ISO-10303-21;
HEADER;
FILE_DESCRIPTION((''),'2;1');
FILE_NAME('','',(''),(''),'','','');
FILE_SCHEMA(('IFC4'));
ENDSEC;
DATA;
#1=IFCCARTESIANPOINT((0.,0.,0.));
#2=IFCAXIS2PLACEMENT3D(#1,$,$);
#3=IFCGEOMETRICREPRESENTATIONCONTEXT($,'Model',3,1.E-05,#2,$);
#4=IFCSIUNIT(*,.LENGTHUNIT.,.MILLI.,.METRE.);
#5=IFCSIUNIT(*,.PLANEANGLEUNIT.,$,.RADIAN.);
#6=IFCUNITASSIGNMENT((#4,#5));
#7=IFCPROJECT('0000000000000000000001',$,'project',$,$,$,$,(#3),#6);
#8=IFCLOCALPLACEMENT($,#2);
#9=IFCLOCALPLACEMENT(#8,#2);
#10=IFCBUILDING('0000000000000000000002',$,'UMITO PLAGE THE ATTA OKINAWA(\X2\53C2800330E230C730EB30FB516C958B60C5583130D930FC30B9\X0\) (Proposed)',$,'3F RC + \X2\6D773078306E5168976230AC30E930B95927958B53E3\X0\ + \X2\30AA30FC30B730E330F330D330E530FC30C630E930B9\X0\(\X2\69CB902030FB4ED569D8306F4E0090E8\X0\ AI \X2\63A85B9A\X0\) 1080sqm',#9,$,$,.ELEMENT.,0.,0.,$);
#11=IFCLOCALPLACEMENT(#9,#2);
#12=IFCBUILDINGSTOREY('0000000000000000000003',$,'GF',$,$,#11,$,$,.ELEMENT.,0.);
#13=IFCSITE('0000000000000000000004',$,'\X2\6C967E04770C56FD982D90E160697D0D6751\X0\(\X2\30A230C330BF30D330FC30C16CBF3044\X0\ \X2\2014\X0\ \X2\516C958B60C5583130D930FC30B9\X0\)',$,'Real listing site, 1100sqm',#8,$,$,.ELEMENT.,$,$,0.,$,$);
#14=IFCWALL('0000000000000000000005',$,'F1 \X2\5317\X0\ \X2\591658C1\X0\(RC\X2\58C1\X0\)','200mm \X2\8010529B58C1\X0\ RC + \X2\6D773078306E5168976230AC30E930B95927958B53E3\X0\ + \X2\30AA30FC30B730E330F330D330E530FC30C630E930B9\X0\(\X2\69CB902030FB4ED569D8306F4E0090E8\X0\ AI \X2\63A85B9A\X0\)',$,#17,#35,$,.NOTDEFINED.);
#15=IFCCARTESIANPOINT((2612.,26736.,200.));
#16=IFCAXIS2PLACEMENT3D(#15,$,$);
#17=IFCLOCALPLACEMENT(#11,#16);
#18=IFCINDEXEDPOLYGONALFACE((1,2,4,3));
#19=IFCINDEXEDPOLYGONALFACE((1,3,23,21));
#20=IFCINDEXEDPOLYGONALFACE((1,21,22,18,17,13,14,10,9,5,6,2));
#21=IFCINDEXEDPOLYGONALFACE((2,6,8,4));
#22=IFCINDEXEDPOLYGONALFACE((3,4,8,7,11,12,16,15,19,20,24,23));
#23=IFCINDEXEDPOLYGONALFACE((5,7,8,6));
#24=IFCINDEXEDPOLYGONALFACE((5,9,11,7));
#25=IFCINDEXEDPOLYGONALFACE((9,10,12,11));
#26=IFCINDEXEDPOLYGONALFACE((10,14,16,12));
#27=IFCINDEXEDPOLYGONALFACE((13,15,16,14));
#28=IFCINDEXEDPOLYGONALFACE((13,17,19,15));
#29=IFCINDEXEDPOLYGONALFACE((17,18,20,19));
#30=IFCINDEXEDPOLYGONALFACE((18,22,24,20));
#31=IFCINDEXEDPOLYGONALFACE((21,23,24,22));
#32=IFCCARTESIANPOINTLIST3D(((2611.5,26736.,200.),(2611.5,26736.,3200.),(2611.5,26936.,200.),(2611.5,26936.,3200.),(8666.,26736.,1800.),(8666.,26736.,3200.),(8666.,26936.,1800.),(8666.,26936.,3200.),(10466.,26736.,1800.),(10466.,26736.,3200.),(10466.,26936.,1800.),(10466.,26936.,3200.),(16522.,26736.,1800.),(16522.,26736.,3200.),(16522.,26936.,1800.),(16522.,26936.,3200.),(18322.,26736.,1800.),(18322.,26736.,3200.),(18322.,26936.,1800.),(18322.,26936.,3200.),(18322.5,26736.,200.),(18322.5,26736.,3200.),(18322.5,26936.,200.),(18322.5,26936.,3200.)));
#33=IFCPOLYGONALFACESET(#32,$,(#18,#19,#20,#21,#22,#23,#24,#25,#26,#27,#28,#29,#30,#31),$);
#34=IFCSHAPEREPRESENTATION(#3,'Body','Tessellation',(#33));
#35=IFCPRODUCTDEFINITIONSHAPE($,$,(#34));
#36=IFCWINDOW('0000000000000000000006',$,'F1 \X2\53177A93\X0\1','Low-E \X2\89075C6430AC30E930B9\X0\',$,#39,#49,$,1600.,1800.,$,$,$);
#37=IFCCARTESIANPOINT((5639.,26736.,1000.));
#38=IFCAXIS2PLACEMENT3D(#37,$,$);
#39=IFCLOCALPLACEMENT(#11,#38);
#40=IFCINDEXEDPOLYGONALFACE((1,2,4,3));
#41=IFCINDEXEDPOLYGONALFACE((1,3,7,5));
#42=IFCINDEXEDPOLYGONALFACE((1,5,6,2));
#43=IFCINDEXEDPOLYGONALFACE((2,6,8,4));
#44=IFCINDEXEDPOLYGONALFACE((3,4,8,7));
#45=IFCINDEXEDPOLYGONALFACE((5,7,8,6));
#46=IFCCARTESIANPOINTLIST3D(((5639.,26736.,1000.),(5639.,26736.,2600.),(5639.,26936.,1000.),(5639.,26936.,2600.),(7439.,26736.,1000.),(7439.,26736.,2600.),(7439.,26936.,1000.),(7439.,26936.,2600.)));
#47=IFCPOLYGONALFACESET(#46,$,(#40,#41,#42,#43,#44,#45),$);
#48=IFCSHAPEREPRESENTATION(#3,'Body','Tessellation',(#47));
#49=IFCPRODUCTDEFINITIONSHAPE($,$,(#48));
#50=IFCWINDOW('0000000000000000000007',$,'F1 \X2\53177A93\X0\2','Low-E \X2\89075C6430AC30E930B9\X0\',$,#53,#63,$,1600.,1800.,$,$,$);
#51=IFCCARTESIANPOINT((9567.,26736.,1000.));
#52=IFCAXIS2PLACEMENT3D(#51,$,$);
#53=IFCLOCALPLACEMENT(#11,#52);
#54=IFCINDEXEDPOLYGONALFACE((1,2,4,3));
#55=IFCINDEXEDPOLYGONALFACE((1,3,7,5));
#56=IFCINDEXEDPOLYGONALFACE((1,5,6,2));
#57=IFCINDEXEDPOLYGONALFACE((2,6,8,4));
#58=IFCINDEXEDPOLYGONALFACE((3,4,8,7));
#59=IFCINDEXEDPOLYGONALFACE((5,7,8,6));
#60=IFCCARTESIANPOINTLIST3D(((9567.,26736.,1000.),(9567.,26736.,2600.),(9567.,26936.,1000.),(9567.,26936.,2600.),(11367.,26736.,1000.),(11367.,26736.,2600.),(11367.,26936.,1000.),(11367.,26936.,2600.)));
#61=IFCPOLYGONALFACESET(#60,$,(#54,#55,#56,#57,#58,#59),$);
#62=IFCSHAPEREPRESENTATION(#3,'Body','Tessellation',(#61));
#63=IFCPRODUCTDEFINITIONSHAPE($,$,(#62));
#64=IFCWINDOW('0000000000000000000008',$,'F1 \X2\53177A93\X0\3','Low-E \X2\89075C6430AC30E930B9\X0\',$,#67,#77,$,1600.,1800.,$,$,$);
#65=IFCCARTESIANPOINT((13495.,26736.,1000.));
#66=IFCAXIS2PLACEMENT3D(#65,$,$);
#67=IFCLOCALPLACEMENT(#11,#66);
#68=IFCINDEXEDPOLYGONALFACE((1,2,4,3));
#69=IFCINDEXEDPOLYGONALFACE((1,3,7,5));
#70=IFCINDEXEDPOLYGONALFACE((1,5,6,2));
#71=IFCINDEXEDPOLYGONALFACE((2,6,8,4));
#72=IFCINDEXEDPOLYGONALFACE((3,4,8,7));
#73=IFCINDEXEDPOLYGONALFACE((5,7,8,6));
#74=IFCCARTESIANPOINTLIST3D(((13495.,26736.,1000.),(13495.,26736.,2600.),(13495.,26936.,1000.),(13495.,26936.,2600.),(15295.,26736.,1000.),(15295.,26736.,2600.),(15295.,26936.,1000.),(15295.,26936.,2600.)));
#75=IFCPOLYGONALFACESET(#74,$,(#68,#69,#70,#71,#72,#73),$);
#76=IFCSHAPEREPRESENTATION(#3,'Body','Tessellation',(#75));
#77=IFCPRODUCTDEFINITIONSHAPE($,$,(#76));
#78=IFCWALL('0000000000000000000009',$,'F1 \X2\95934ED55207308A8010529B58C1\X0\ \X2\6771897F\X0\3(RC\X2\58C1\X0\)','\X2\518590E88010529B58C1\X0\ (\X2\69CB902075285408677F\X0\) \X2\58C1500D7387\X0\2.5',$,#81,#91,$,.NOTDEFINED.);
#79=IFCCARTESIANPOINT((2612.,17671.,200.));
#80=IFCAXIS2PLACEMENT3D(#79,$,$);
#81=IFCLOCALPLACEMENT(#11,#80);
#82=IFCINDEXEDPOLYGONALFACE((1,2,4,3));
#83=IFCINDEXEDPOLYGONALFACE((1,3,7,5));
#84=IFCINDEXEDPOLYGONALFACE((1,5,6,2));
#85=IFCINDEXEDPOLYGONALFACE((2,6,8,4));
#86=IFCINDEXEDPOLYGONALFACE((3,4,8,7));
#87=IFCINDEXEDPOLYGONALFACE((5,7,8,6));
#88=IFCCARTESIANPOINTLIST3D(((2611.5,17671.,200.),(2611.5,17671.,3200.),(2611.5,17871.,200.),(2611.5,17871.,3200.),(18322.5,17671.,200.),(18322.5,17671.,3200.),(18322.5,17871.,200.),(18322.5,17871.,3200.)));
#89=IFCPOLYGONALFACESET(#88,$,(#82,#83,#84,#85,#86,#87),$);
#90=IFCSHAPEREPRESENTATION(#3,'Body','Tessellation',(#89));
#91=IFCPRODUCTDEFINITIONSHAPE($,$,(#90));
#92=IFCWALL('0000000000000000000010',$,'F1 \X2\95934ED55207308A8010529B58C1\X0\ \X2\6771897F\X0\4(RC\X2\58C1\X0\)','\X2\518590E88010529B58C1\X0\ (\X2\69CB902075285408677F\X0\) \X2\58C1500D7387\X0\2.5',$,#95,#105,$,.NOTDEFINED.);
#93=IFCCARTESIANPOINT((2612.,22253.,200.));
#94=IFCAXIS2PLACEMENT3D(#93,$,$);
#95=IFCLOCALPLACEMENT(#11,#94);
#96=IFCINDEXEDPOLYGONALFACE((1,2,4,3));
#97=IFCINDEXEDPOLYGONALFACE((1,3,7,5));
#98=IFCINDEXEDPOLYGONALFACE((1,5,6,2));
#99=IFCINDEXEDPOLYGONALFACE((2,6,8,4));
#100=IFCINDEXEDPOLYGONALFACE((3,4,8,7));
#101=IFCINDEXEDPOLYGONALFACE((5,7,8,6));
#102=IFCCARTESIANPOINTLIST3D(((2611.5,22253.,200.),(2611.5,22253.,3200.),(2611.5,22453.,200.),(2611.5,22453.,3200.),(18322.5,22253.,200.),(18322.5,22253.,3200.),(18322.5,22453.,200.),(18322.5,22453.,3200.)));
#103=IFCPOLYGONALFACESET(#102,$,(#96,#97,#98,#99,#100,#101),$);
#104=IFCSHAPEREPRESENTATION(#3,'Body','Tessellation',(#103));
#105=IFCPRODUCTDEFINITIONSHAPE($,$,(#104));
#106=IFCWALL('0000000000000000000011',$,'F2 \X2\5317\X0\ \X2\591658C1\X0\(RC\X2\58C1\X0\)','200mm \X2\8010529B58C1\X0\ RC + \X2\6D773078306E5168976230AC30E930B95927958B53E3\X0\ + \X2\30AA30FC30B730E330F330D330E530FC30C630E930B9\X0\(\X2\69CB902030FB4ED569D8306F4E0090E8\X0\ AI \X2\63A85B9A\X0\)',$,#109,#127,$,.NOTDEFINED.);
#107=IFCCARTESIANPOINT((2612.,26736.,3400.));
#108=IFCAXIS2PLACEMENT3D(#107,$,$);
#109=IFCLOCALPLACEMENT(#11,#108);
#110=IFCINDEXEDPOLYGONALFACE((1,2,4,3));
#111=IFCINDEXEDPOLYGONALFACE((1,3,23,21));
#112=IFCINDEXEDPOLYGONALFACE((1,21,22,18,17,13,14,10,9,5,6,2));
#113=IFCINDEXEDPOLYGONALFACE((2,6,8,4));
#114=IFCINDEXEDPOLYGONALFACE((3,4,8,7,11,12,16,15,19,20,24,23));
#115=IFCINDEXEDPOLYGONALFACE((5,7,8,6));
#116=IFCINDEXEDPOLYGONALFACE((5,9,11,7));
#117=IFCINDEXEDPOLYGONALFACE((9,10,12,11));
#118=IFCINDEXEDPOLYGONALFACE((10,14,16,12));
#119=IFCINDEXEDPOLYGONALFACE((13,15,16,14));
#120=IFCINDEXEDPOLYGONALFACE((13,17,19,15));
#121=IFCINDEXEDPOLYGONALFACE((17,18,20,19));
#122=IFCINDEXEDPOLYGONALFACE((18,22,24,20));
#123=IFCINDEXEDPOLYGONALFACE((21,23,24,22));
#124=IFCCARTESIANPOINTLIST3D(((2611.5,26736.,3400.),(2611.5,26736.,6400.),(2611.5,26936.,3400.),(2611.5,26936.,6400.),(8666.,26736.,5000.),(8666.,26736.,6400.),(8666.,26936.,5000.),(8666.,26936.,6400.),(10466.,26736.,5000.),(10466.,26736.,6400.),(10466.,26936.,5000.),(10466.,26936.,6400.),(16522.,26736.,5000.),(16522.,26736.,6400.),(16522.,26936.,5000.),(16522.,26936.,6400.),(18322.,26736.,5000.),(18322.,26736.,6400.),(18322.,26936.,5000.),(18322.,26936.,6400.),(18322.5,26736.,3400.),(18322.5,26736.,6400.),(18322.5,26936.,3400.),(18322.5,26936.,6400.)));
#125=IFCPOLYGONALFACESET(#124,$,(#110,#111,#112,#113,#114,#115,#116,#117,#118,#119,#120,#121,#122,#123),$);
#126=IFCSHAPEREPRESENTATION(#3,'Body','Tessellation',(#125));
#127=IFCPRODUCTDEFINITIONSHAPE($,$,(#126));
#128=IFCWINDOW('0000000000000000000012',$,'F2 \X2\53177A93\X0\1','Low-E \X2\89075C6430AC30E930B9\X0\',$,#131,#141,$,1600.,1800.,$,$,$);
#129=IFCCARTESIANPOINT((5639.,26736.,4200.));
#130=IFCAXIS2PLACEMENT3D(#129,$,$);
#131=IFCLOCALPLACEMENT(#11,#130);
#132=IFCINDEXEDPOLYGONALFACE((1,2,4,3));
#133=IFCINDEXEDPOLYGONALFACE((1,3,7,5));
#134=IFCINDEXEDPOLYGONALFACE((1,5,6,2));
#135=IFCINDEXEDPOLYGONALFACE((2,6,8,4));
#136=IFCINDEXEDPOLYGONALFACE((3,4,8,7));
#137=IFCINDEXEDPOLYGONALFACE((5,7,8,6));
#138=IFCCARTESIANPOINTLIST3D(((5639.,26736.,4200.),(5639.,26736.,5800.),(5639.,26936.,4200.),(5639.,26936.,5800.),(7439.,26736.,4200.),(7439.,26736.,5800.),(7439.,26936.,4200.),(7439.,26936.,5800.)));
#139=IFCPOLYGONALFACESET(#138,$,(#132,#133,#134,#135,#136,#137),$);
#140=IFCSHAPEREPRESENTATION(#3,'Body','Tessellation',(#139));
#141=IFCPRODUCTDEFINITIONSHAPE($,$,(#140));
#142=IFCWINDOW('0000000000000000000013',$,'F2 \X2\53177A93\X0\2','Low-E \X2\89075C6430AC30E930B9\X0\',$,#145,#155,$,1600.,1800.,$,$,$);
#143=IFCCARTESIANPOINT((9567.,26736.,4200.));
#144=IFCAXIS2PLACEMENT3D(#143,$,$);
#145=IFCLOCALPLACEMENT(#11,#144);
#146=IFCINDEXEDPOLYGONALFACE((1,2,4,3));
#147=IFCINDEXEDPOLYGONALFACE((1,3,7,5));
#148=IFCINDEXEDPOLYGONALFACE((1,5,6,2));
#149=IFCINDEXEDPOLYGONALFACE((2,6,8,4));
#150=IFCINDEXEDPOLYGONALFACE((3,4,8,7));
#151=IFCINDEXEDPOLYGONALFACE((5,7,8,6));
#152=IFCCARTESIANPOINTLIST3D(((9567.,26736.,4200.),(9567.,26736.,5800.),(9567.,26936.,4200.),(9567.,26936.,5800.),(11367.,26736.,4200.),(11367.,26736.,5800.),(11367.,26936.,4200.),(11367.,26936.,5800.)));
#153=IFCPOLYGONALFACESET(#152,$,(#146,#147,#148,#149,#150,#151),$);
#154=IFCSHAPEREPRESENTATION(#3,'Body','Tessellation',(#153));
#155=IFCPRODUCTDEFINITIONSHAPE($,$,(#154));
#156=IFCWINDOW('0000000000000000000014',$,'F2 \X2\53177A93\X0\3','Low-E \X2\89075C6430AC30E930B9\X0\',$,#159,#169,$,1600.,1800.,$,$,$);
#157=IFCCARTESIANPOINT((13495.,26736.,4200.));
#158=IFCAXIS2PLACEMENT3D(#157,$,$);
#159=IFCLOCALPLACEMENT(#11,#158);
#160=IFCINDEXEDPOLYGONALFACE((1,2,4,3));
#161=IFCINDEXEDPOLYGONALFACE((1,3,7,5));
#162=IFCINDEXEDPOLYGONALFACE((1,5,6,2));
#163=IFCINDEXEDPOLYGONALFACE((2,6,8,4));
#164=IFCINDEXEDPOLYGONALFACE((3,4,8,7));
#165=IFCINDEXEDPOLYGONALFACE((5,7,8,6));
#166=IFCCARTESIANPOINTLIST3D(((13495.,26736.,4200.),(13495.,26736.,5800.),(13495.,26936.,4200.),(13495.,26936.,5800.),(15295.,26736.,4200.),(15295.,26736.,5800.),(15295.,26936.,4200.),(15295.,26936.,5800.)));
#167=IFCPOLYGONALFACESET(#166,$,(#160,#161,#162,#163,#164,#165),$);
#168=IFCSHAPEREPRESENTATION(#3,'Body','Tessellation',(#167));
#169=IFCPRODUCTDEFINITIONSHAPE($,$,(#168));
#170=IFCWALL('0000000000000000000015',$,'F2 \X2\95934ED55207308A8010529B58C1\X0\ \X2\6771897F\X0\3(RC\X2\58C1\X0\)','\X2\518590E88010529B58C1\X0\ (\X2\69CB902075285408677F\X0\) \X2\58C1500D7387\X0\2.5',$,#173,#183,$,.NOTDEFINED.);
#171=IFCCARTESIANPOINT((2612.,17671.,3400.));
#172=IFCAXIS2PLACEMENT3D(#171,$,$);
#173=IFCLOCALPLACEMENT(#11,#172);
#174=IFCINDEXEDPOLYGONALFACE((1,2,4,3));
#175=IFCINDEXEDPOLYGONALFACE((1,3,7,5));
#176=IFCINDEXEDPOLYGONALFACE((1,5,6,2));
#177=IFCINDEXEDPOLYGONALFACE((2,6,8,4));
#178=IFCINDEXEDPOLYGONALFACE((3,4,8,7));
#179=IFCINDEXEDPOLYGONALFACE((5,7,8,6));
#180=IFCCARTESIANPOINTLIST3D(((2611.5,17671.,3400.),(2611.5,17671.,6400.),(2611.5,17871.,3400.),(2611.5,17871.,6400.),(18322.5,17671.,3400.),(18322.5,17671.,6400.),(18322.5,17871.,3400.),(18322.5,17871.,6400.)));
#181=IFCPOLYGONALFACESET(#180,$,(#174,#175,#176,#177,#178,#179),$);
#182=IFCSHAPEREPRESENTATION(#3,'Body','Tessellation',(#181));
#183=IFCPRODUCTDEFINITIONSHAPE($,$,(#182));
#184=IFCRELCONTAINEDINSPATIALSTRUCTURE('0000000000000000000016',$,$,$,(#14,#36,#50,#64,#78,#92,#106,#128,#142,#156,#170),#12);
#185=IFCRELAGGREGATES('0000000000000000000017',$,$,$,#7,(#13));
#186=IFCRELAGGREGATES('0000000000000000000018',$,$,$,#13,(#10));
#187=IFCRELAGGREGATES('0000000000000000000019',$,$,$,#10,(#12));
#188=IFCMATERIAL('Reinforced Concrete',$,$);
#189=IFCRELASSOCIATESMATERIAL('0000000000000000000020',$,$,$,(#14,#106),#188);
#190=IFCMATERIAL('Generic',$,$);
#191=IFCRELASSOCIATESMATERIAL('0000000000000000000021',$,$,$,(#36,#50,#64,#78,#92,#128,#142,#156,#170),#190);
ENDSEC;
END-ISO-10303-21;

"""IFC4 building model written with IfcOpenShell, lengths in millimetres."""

from ifc_helpers import new_model, si_unit, frame, frame_2d, origin, place, context, project, spatial, rectangle, extrude, material, element, fill, save


model = new_model("IFC4")

# Units and contexts
model_context = context("Model", 3, precision=1e-05, world=origin())
ifc_project = project(units=[si_unit("LENGTHUNIT", "METRE", prefix="MILLI"), si_unit("PLANEANGLEUNIT", "RADIAN")], contexts=[model_context])

# Site, building, storey
site_placement = place(None, origin())
site = spatial("IfcSite", under=ifc_project, at=site_placement, Name="沖縄県国頭郡恩納村(アッタビーチ沿い — 公開情報ベース)", ObjectType="Real listing site, 1100sqm", CompositionType="ELEMENT", RefElevation=0.0)
building_placement = place(site_placement, origin())
building = spatial("IfcBuilding", under=site, at=building_placement, Name="UMITO PLAGE THE ATTA OKINAWA(参考モデル・公開情報ベース) (Proposed)", ObjectType="3F RC + 海への全面ガラス大開口 + オーシャンビューテラス(構造・仕様は一部 AI 推定) 1080sqm", CompositionType="ELEMENT", ElevationOfRefHeight=0.0, ElevationOfTerrain=0.0)
storey_placement = place(building_placement, origin())
storey = spatial("IfcBuildingStorey", under=building, at=storey_placement, Name="GF", CompositionType="ELEMENT", Elevation=0.0)

# Wall, openings, windows
ifc_material_1 = material(Name="Reinforced Concrete")
wall_1_placement = place(storey_placement, frame((2612.0, 26736.0, 200.0)))
wall_1 = element("IfcWall", 1, at=wall_1_placement, inside=storey, material=ifc_material_1, Name="F1 北 外壁(RC壁)", Description="200mm 耐力壁 RC + 海への全面ガラス大開口 + オーシャンビューテラス(構造・仕様は一部 AI 推定)", PredefinedType="NOTDEFINED", context=model_context, shape_type="SweptSolid", body=[
    extrude(rectangle(XDim=15711.0, YDim=200.0, at=frame_2d((7855.0, 100.0))), frame((2612.0, 26736.0, 200.0)), (0.0, 0.0, 1.0), 3000.0),
])
opening_1_placement = place(storey_placement, frame((5639.0, 26736.0, 1000.0)))
opening_1 = element("IfcOpeningElement", 2, at=opening_1_placement, cuts=wall_1, PredefinedType="NOTDEFINED", context=model_context, shape_type="SweptSolid", body=[
    extrude(rectangle(XDim=1800.0, YDim=200.0, at=frame_2d((900.0, 100.0))), frame((5639.0, 26736.0, 1000.0)), (0.0, 0.0, 1.0), 1600.0),
])
opening_2_placement = place(storey_placement, frame((9567.0, 26736.0, 1000.0)))
opening_2 = element("IfcOpeningElement", 3, at=opening_2_placement, cuts=wall_1, PredefinedType="NOTDEFINED", context=model_context, shape_type="SweptSolid", body=[
    extrude(rectangle(XDim=1800.0, YDim=200.0, at=frame_2d((900.0, 100.0))), frame((9567.0, 26736.0, 1000.0)), (0.0, 0.0, 1.0), 1600.0),
])
opening_3_placement = place(storey_placement, frame((13495.0, 26736.0, 1000.0)))
opening_3 = element("IfcOpeningElement", 4, at=opening_3_placement, cuts=wall_1, PredefinedType="NOTDEFINED", context=model_context, shape_type="SweptSolid", body=[
    extrude(rectangle(XDim=1800.0, YDim=200.0, at=frame_2d((900.0, 100.0))), frame((13495.0, 26736.0, 1000.0)), (0.0, 0.0, 1.0), 1600.0),
])
ifc_material_2 = material(Name="Generic")
window_1_placement = place(storey_placement, frame((5639.0, 26736.0, 1000.0)))
window_1 = element("IfcWindow", 5, at=window_1_placement, inside=storey, material=ifc_material_2, Name="F1 北窓1", Description="Low-E 複層ガラス", OverallHeight=1600.0, OverallWidth=1800.0, context=model_context, shape_type="SweptSolid", body=[
    extrude(rectangle(XDim=1800.0, YDim=200.0, at=frame_2d((900.0, 100.0))), frame((5639.0, 26736.0, 1000.0)), (0.0, 0.0, 1.0), 1600.0),
])
fill(opening_1, window_1)
window_2_placement = place(storey_placement, frame((9567.0, 26736.0, 1000.0)))
window_2 = element("IfcWindow", 6, at=window_2_placement, inside=storey, material=ifc_material_2, Name="F1 北窓2", Description="Low-E 複層ガラス", OverallHeight=1600.0, OverallWidth=1800.0, context=model_context, shape_type="SweptSolid", body=[
    extrude(rectangle(XDim=1800.0, YDim=200.0, at=frame_2d((900.0, 100.0))), frame((9567.0, 26736.0, 1000.0)), (0.0, 0.0, 1.0), 1600.0),
])
fill(opening_2, window_2)
window_3_placement = place(storey_placement, frame((13495.0, 26736.0, 1000.0)))
window_3 = element("IfcWindow", 7, at=window_3_placement, inside=storey, material=ifc_material_2, Name="F1 北窓3", Description="Low-E 複層ガラス", OverallHeight=1600.0, OverallWidth=1800.0, context=model_context, shape_type="SweptSolid", body=[
    extrude(rectangle(XDim=1800.0, YDim=200.0, at=frame_2d((900.0, 100.0))), frame((13495.0, 26736.0, 1000.0)), (0.0, 0.0, 1.0), 1600.0),
])
fill(opening_3, window_3)

# Walls
wall_2_placement = place(storey_placement, frame((2612.0, 17671.0, 200.0)))
element("IfcWall", 8, at=wall_2_placement, inside=storey, material=ifc_material_2, Name="F1 間仕切り耐力壁 東西3(RC壁)", Description="内部耐力壁 (構造用合板) 壁倍率2.5", PredefinedType="NOTDEFINED", context=model_context, shape_type="SweptSolid", body=[
    extrude(rectangle(XDim=15711.0, YDim=200.0, at=frame_2d((7855.0, 100.0))), frame((2612.0, 17671.0, 200.0)), (0.0, 0.0, 1.0), 3000.0),
])
wall_3_placement = place(storey_placement, frame((2612.0, 22253.0, 200.0)))
element("IfcWall", 9, at=wall_3_placement, inside=storey, material=ifc_material_2, Name="F1 間仕切り耐力壁 東西4(RC壁)", Description="内部耐力壁 (構造用合板) 壁倍率2.5", PredefinedType="NOTDEFINED", context=model_context, shape_type="SweptSolid", body=[
    extrude(rectangle(XDim=15711.0, YDim=200.0, at=frame_2d((7855.0, 100.0))), frame((2612.0, 22253.0, 200.0)), (0.0, 0.0, 1.0), 3000.0),
])

# Wall, openings, windows
wall_4_placement = place(storey_placement, frame((2612.0, 26736.0, 3400.0)))
wall_4 = element("IfcWall", 10, at=wall_4_placement, inside=storey, material=ifc_material_1, Name="F2 北 外壁(RC壁)", Description="200mm 耐力壁 RC + 海への全面ガラス大開口 + オーシャンビューテラス(構造・仕様は一部 AI 推定)", PredefinedType="NOTDEFINED", context=model_context, shape_type="SweptSolid", body=[
    extrude(rectangle(XDim=15711.0, YDim=200.0, at=frame_2d((7855.0, 100.0))), frame((2612.0, 26736.0, 3400.0)), (0.0, 0.0, 1.0), 3000.0),
])
opening_4_placement = place(storey_placement, frame((5639.0, 26736.0, 4200.0)))
opening_4 = element("IfcOpeningElement", 11, at=opening_4_placement, cuts=wall_4, PredefinedType="NOTDEFINED", context=model_context, shape_type="SweptSolid", body=[
    extrude(rectangle(XDim=1800.0, YDim=200.0, at=frame_2d((900.0, 100.0))), frame((5639.0, 26736.0, 4200.0)), (0.0, 0.0, 1.0), 1600.0),
])
opening_5_placement = place(storey_placement, frame((9567.0, 26736.0, 4200.0)))
opening_5 = element("IfcOpeningElement", 12, at=opening_5_placement, cuts=wall_4, PredefinedType="NOTDEFINED", context=model_context, shape_type="SweptSolid", body=[
    extrude(rectangle(XDim=1800.0, YDim=200.0, at=frame_2d((900.0, 100.0))), frame((9567.0, 26736.0, 4200.0)), (0.0, 0.0, 1.0), 1600.0),
])
opening_6_placement = place(storey_placement, frame((13495.0, 26736.0, 4200.0)))
opening_6 = element("IfcOpeningElement", 13, at=opening_6_placement, cuts=wall_4, PredefinedType="NOTDEFINED", context=model_context, shape_type="SweptSolid", body=[
    extrude(rectangle(XDim=1800.0, YDim=200.0, at=frame_2d((900.0, 100.0))), frame((13495.0, 26736.0, 4200.0)), (0.0, 0.0, 1.0), 1600.0),
])
window_4_placement = place(storey_placement, frame((5639.0, 26736.0, 4200.0)))
window_4 = element("IfcWindow", 14, at=window_4_placement, inside=storey, material=ifc_material_2, Name="F2 北窓1", Description="Low-E 複層ガラス", OverallHeight=1600.0, OverallWidth=1800.0, context=model_context, shape_type="SweptSolid", body=[
    extrude(rectangle(XDim=1800.0, YDim=200.0, at=frame_2d((900.0, 100.0))), frame((5639.0, 26736.0, 4200.0)), (0.0, 0.0, 1.0), 1600.0),
])
fill(opening_4, window_4)
window_5_placement = place(storey_placement, frame((9567.0, 26736.0, 4200.0)))
window_5 = element("IfcWindow", 15, at=window_5_placement, inside=storey, material=ifc_material_2, Name="F2 北窓2", Description="Low-E 複層ガラス", OverallHeight=1600.0, OverallWidth=1800.0, context=model_context, shape_type="SweptSolid", body=[
    extrude(rectangle(XDim=1800.0, YDim=200.0, at=frame_2d((900.0, 100.0))), frame((9567.0, 26736.0, 4200.0)), (0.0, 0.0, 1.0), 1600.0),
])
fill(opening_5, window_5)
window_6_placement = place(storey_placement, frame((13495.0, 26736.0, 4200.0)))
window_6 = element("IfcWindow", 16, at=window_6_placement, inside=storey, material=ifc_material_2, Name="F2 北窓3", Description="Low-E 複層ガラス", OverallHeight=1600.0, OverallWidth=1800.0, context=model_context, shape_type="SweptSolid", body=[
    extrude(rectangle(XDim=1800.0, YDim=200.0, at=frame_2d((900.0, 100.0))), frame((13495.0, 26736.0, 4200.0)), (0.0, 0.0, 1.0), 1600.0),
])
fill(opening_6, window_6)

# Wall
wall_5_placement = place(storey_placement, frame((2612.0, 17671.0, 3400.0)))
element("IfcWall", 17, at=wall_5_placement, inside=storey, material=ifc_material_2, Name="F2 間仕切り耐力壁 東西3(RC壁)", Description="内部耐力壁 (構造用合板) 壁倍率2.5", PredefinedType="NOTDEFINED", context=model_context, shape_type="SweptSolid", body=[
    extrude(rectangle(XDim=15711.0, YDim=200.0, at=frame_2d((7855.0, 100.0))), frame((2612.0, 17671.0, 3400.0)), (0.0, 0.0, 1.0), 3000.0),
])

save(model, "model.ifc")
